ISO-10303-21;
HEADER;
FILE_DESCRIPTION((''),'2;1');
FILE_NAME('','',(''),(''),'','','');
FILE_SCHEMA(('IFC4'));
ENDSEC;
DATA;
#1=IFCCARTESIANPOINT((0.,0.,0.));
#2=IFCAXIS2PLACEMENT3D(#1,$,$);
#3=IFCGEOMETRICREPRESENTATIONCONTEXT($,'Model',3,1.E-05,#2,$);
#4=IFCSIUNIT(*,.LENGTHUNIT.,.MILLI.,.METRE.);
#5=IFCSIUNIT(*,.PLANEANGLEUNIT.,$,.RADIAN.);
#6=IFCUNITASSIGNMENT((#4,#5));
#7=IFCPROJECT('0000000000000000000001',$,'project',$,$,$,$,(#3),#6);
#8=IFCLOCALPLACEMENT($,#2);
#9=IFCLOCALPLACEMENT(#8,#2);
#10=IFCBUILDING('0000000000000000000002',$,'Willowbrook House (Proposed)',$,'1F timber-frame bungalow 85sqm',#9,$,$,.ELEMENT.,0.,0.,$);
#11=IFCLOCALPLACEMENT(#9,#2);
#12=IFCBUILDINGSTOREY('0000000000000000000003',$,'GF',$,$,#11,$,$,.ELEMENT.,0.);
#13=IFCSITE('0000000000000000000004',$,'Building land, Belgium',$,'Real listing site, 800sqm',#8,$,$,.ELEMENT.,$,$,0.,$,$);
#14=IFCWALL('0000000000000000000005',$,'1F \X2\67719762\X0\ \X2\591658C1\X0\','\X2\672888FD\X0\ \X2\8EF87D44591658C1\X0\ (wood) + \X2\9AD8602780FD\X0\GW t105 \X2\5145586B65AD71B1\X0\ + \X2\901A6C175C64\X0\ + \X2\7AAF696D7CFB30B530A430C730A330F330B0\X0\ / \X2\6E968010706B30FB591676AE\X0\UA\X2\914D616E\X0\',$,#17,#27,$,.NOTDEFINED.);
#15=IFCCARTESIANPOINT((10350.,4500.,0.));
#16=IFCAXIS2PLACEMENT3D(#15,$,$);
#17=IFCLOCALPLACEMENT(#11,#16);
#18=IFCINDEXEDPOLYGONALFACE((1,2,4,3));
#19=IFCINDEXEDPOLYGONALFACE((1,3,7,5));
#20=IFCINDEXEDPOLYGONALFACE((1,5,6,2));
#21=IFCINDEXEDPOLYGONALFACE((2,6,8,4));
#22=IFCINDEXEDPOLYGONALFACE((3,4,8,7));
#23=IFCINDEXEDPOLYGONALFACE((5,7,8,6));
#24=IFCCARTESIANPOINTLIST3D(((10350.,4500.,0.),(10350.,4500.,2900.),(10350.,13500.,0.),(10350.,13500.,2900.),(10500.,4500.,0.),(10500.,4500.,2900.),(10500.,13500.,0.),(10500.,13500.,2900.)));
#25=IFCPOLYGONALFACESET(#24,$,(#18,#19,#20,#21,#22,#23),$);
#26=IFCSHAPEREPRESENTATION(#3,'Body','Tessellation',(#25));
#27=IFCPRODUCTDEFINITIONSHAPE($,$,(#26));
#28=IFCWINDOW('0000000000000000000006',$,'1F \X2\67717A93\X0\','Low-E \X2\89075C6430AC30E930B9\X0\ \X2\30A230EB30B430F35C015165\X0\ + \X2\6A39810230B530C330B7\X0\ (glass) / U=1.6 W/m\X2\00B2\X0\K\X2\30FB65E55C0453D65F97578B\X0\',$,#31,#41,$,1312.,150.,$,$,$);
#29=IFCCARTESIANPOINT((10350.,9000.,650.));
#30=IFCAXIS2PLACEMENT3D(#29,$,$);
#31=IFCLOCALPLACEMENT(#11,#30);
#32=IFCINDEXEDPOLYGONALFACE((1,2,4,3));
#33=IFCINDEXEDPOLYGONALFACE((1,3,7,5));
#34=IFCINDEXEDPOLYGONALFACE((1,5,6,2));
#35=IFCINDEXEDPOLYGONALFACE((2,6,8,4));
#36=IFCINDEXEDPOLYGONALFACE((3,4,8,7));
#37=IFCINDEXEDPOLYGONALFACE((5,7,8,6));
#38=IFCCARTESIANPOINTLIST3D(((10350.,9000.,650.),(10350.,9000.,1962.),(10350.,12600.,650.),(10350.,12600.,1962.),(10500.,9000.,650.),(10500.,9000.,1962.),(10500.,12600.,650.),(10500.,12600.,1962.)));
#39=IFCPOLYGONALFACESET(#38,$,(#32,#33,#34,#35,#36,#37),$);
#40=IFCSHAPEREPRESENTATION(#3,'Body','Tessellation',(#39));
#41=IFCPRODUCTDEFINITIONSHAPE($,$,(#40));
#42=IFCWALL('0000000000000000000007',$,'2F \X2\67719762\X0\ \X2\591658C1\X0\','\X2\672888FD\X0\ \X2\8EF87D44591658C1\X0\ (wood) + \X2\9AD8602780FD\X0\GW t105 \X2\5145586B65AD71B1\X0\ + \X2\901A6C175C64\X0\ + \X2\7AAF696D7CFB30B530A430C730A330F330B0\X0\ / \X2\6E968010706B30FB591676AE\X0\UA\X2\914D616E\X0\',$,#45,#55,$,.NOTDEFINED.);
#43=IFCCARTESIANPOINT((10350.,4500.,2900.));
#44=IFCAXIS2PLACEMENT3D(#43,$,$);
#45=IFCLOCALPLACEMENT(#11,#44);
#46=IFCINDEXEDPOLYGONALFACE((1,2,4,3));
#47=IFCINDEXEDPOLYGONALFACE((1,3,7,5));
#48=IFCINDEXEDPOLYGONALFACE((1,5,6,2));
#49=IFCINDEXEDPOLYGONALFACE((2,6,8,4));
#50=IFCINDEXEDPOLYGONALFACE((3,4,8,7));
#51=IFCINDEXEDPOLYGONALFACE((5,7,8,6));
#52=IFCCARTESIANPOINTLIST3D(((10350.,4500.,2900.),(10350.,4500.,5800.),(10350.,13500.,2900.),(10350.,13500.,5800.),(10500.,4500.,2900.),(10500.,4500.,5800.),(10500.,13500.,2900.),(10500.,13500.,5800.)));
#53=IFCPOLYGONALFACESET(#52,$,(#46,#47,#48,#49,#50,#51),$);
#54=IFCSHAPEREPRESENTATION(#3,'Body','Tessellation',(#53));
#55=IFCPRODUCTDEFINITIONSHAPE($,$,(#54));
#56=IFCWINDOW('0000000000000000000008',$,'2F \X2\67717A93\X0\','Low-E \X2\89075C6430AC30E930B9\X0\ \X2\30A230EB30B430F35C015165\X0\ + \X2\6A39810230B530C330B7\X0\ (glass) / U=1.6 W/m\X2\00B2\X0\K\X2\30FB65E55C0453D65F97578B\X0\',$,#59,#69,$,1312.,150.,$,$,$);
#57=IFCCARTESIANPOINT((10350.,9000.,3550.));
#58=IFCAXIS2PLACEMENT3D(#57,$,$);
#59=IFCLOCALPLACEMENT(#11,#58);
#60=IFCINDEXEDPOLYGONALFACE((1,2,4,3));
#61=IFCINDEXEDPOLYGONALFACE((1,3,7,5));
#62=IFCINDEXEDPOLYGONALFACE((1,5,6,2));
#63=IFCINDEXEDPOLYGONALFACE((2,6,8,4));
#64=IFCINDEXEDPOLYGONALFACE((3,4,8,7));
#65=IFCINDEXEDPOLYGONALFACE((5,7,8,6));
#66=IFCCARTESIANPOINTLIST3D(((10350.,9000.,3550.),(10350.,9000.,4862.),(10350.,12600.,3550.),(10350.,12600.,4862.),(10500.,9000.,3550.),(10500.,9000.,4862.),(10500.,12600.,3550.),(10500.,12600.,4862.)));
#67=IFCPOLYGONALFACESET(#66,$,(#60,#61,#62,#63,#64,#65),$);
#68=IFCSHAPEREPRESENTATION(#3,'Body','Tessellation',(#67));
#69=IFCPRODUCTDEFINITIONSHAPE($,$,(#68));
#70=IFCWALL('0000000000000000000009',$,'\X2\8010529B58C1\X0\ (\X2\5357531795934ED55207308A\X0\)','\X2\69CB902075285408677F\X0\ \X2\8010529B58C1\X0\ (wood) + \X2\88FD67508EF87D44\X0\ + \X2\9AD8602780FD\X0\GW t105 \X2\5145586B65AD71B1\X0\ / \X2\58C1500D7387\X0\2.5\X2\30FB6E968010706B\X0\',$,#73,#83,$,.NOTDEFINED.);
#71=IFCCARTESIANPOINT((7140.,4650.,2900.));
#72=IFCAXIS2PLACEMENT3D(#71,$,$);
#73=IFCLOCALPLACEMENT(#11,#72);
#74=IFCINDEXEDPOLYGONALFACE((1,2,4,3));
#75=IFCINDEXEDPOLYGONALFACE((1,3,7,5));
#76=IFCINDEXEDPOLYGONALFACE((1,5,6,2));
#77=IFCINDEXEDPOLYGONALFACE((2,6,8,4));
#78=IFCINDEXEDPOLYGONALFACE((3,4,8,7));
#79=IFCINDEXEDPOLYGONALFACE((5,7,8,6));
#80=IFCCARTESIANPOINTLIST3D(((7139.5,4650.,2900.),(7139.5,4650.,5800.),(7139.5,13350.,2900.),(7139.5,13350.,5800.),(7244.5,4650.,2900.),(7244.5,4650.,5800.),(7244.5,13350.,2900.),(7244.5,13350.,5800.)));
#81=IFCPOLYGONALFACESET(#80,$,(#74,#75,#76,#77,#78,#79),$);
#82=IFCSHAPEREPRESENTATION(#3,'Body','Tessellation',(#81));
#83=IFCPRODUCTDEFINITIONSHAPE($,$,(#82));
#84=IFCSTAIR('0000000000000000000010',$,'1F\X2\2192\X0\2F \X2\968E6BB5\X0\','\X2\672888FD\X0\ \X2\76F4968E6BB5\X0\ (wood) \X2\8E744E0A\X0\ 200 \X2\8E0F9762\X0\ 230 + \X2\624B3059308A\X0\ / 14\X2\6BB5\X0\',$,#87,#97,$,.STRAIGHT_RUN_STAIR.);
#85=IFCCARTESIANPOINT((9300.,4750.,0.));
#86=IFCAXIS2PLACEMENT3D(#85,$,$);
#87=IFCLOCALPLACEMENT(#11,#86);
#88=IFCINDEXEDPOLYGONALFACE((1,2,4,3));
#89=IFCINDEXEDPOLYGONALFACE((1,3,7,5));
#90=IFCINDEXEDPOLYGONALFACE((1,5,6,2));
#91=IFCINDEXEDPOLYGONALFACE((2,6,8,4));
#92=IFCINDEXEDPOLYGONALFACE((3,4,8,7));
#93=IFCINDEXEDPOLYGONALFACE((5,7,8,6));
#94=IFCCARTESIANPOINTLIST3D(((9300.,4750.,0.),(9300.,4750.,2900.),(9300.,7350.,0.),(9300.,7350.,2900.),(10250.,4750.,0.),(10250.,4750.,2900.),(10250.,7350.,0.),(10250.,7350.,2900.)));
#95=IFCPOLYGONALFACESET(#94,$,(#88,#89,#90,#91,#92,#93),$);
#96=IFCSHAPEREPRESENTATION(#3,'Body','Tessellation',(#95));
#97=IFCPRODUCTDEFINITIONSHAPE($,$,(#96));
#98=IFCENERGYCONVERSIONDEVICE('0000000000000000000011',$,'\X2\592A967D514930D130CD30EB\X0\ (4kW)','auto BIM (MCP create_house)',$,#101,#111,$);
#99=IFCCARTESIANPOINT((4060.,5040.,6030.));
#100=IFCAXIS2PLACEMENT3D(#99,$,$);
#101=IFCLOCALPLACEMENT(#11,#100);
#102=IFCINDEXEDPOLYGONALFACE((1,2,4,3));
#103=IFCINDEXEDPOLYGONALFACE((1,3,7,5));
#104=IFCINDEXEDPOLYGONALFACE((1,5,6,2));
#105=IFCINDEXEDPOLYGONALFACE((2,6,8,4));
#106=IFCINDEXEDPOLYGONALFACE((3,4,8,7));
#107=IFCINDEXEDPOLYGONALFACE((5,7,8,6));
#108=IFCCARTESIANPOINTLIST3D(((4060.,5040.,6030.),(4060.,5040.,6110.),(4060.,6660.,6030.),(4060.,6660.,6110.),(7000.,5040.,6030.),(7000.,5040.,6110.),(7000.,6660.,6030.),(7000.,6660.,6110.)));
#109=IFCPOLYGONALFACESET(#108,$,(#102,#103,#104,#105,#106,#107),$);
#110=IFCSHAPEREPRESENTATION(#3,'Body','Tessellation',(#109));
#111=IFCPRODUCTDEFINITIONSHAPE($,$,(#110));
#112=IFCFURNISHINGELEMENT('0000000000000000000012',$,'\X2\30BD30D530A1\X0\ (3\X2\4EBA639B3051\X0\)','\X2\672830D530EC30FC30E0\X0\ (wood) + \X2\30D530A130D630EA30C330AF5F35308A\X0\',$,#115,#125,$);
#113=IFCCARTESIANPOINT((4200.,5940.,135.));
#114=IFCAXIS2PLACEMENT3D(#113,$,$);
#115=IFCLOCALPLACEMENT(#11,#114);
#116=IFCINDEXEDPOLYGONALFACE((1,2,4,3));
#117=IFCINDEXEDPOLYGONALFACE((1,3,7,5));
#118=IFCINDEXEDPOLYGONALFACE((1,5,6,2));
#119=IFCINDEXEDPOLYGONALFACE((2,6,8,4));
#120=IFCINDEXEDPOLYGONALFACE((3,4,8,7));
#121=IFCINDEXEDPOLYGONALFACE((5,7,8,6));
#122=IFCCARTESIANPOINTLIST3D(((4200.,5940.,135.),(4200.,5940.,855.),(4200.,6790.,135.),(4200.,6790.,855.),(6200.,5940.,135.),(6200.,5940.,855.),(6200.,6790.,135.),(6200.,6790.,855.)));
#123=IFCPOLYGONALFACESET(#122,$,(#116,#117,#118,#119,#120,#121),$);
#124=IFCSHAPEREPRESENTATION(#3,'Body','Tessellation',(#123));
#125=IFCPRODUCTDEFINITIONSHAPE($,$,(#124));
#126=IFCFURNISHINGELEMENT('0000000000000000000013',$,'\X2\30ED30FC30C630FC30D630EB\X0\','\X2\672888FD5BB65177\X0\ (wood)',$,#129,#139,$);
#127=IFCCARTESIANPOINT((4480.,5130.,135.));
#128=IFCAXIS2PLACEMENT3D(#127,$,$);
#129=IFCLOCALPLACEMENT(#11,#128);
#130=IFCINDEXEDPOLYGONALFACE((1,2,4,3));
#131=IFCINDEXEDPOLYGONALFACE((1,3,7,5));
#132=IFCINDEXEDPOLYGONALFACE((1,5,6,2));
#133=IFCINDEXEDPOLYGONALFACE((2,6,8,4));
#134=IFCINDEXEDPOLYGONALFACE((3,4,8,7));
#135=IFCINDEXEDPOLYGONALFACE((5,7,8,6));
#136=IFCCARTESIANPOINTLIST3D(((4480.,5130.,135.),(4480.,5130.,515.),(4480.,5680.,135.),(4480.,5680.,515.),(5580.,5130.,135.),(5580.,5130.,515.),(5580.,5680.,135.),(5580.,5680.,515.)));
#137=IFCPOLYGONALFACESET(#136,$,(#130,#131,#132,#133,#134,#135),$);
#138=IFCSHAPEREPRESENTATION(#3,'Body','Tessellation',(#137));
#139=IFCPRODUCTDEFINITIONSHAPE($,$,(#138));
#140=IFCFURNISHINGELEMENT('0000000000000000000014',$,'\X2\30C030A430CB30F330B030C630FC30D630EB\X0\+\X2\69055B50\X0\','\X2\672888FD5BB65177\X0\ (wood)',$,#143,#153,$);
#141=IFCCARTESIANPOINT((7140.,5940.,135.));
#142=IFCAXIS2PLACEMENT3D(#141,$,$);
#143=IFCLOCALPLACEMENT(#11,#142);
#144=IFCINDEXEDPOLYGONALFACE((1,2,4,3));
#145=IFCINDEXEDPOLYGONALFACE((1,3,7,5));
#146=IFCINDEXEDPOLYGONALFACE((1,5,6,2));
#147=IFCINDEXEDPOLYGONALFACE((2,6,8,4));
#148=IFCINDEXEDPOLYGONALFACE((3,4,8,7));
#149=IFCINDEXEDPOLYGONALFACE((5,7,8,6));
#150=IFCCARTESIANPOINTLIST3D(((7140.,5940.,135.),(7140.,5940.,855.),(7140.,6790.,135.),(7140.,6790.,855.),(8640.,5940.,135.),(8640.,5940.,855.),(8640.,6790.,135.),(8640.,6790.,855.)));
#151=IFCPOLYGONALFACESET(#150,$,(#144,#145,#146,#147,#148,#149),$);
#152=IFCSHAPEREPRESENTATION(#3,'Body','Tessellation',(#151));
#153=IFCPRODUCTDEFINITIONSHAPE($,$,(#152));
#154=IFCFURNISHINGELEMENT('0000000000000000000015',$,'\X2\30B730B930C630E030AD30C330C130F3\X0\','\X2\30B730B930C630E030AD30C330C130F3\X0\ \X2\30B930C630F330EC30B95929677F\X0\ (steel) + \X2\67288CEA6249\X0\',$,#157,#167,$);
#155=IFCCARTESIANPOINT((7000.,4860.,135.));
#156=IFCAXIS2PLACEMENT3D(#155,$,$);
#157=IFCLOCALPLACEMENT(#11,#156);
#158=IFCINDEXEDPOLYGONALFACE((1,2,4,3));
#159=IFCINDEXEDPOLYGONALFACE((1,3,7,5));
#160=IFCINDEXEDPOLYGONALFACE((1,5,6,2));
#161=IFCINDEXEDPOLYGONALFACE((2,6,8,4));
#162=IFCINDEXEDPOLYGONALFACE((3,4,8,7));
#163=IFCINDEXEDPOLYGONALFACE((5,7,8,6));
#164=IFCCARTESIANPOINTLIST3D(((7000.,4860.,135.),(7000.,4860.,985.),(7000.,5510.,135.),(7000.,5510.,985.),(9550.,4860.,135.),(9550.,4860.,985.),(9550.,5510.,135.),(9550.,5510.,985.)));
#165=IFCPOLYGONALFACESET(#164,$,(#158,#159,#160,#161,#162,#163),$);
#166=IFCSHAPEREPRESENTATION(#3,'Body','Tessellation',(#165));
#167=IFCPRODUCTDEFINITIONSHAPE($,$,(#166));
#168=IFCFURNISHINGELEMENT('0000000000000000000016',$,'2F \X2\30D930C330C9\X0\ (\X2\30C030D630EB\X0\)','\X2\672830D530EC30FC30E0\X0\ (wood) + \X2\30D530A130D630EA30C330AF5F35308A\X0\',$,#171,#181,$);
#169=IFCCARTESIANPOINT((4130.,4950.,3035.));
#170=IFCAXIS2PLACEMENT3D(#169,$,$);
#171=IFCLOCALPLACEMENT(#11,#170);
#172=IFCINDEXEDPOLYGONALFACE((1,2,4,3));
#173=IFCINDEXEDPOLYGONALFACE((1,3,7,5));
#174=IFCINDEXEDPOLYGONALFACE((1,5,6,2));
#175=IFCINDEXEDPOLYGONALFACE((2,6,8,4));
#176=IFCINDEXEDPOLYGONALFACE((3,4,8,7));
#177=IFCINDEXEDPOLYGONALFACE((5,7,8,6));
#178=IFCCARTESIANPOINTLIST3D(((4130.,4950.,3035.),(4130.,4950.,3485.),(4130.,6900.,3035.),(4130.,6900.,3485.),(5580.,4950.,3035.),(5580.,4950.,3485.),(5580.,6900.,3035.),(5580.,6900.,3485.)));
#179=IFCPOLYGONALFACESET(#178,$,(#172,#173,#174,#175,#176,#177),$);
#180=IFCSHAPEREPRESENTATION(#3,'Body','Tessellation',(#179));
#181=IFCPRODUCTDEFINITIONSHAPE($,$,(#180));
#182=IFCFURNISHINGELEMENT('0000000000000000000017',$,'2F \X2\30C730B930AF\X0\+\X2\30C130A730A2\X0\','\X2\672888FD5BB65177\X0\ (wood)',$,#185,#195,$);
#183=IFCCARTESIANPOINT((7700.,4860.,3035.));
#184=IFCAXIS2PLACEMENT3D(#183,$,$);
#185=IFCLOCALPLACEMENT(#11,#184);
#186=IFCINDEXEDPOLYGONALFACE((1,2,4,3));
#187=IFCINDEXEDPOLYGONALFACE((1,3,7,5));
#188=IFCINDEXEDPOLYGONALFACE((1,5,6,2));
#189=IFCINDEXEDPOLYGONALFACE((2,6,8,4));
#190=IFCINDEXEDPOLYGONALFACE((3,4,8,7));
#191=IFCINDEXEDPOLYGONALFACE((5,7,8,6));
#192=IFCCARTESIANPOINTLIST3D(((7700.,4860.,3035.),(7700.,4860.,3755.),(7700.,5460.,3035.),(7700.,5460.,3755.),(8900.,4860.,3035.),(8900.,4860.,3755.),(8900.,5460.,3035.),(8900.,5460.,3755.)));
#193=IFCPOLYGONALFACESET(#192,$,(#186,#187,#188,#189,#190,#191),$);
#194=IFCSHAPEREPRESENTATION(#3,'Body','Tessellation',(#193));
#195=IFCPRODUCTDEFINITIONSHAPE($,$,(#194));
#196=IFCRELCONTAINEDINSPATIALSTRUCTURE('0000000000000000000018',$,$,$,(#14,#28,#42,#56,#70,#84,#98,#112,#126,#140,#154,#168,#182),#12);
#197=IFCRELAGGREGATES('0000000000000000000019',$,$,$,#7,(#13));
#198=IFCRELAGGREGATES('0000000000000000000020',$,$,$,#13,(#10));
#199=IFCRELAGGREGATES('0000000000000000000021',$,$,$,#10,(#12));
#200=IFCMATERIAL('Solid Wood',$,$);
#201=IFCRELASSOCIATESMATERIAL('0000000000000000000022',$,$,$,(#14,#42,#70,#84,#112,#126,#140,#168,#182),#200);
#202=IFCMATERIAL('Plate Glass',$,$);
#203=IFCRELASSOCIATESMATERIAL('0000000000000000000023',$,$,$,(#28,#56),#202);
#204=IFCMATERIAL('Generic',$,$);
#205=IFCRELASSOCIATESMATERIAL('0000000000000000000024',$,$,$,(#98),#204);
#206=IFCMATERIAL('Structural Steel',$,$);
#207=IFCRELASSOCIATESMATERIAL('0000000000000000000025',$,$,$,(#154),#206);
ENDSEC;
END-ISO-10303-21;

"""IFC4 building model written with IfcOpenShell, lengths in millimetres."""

from ifc_helpers import new_model, si_unit, frame, frame_2d, origin, place, context, project, spatial, rectangle, extrude, material, element, fill, save


model = new_model("IFC4")

# Units and contexts
model_context = context("Model", 3, precision=1e-05, world=origin())
ifc_project = project(units=[si_unit("LENGTHUNIT", "METRE", prefix="MILLI"), si_unit("PLANEANGLEUNIT", "RADIAN")], contexts=[model_context])

# Site, building, storey
site_placement = place(None, origin())
site = spatial("IfcSite", under=ifc_project, at=site_placement, Name="Building land, Belgium", ObjectType="Real listing site, 800sqm", CompositionType="ELEMENT", RefElevation=0.0)
building_placement = place(site_placement, origin())
building = spatial("IfcBuilding", under=site, at=building_placement, Name="Willowbrook House (Proposed)", ObjectType="1F timber-frame bungalow 85sqm", CompositionType="ELEMENT", ElevationOfRefHeight=0.0, ElevationOfTerrain=0.0)
storey_placement = place(building_placement, origin())
storey = spatial("IfcBuildingStorey", under=building, at=storey_placement, Name="GF", CompositionType="ELEMENT", Elevation=0.0)

# Wall, opening, window
ifc_material_1 = material(Name="Solid Wood")
wall_1_placement = place(storey_placement, frame((10350.0, 4500.0, 0.0)))
wall_1 = element("IfcWall", 1, at=wall_1_placement, inside=storey, material=ifc_material_1, Name="1F 東面 外壁", Description="木製 軸組外壁 (wood) + 高性能GW t105 充填断熱 + 通気層 + 窯業系サイディング / 準耐火・外皮UA配慮", PredefinedType="NOTDEFINED", context=model_context, shape_type="SweptSolid", body=[
    extrude(rectangle(XDim=150.0, YDim=9000.0, at=frame_2d((75.0, 4500.0))), frame((10350.0, 4500.0, 0.0)), (0.0, 0.0, 1.0), 2900.0),
])
opening_1_placement = place(storey_placement, frame((10350.0, 9000.0, 650.0)))
opening_1 = element("IfcOpeningElement", 2, at=opening_1_placement, cuts=wall_1, PredefinedType="NOTDEFINED", context=model_context, shape_type="SweptSolid", body=[
    extrude(rectangle(XDim=150.0, YDim=3600.0, at=frame_2d((75.0, 1800.0))), frame((10350.0, 9000.0, 650.0)), (0.0, 0.0, 1.0), 1312.0),
])
ifc_material_2 = material(Name="Plate Glass")
window_1_placement = place(storey_placement, frame((10350.0, 9000.0, 650.0)))
window_1 = element("IfcWindow", 3, at=window_1_placement, inside=storey, material=ifc_material_2, Name="1F 東窓", Description="Low-E 複層ガラス アルゴン封入 + 樹脂サッシ (glass) / U=1.6 W/m²K・日射取得型", OverallHeight=1312.0, OverallWidth=150.0, context=model_context, shape_type="SweptSolid", body=[
    extrude(rectangle(XDim=150.0, YDim=3600.0, at=frame_2d((75.0, 1800.0))), frame((10350.0, 9000.0, 650.0)), (0.0, 0.0, 1.0), 1312.0),
])
fill(opening_1, window_1)

# Wall, opening, window
wall_2_placement = place(storey_placement, frame((10350.0, 4500.0, 2900.0)))
wall_2 = element("IfcWall", 4, at=wall_2_placement, inside=storey, material=ifc_material_1, Name="2F 東面 外壁", Description="木製 軸組外壁 (wood) + 高性能GW t105 充填断熱 + 通気層 + 窯業系サイディング / 準耐火・外皮UA配慮", PredefinedType="NOTDEFINED", context=model_context, shape_type="SweptSolid", body=[
    extrude(rectangle(XDim=150.0, YDim=9000.0, at=frame_2d((75.0, 4500.0))), frame((10350.0, 4500.0, 2900.0)), (0.0, 0.0, 1.0), 2900.0),
])
opening_2_placement = place(storey_placement, frame((10350.0, 9000.0, 3550.0)))
opening_2 = element("IfcOpeningElement", 5, at=opening_2_placement, cuts=wall_2, PredefinedType="NOTDEFINED", context=model_context, shape_type="SweptSolid", body=[
    extrude(rectangle(XDim=150.0, YDim=3600.0, at=frame_2d((75.0, 1800.0))), frame((10350.0, 9000.0, 3550.0)), (0.0, 0.0, 1.0), 1312.0),
])
window_2_placement = place(storey_placement, frame((10350.0, 9000.0, 3550.0)))
window_2 = element("IfcWindow", 6, at=window_2_placement, inside=storey, material=ifc_material_2, Name="2F 東窓", Description="Low-E 複層ガラス アルゴン封入 + 樹脂サッシ (glass) / U=1.6 W/m²K・日射取得型", OverallHeight=1312.0, OverallWidth=150.0, context=model_context, shape_type="SweptSolid", body=[
    extrude(rectangle(XDim=150.0, YDim=3600.0, at=frame_2d((75.0, 1800.0))), frame((10350.0, 9000.0, 3550.0)), (0.0, 0.0, 1.0), 1312.0),
])
fill(opening_2, window_2)

# Wall
wall_3_placement = place(storey_placement, frame((7140.0, 4650.0, 2900.0)))
element("IfcWall", 7, at=wall_3_placement, inside=storey, material=ifc_material_1, Name="耐力壁 (南北間仕切り)", Description="構造用合板 耐力壁 (wood) + 製材軸組 + 高性能GW t105 充填断熱 / 壁倍率2.5・準耐火", PredefinedType="NOTDEFINED", context=model_context, shape_type="SweptSolid", body=[
    extrude(rectangle(XDim=105.0, YDim=8700.0, at=frame_2d((52.0, 4350.0))), frame((7140.0, 4650.0, 2900.0)), (0.0, 0.0, 1.0), 2900.0),
])

# Stair
stair_placement = place(storey_placement, frame((9300.0, 4750.0, 0.0)))
element("IfcStair", 8, at=stair_placement, inside=storey, material=ifc_material_1, Name="1F→2F 階段", Description="木製 直階段 (wood) 蹴上 200 踏面 230 + 手すり / 14段", PredefinedType="STRAIGHT_RUN_STAIR", context=model_context, shape_type="SweptSolid", body=[
    extrude(rectangle(XDim=950.0, YDim=2600.0, at=frame_2d((475.0, 1300.0))), frame((9300.0, 4750.0, 0.0)), (0.0, 0.0, 1.0), 2900.0),
])

# Energy conversion device
ifc_material_3 = material(Name="Generic")
energy_conversion_device_placement = place(storey_placement, frame((4060.0, 5040.0, 6030.0)))
element("IfcEnergyConversionDevice", 9, at=energy_conversion_device_placement, inside=storey, material=ifc_material_3, Name="太陽光パネル (4kW)", Description="auto BIM (MCP create_house)", context=model_context, shape_type="SweptSolid", body=[
    extrude(rectangle(XDim=2940.0, YDim=1620.0, at=frame_2d((1470.0, 810.0))), frame((4060.0, 5040.0, 6030.0)), (0.0, 0.0, 1.0), 80.0),
])

# Furnishing elements
furnishing_1_placement = place(storey_placement, frame((4200.0, 5940.0, 135.0)))
element("IfcFurnishingElement", 10, at=furnishing_1_placement, inside=storey, material=ifc_material_1, Name="ソファ (3人掛け)", Description="木フレーム (wood) + ファブリック張り", context=model_context, shape_type="SweptSolid", body=[
    extrude(rectangle(XDim=2000.0, YDim=850.0, at=frame_2d((1000.0, 425.0))), frame((4200.0, 5940.0, 135.0)), (0.0, 0.0, 1.0), 720.0),
])
furnishing_2_placement = place(storey_placement, frame((4480.0, 5130.0, 135.0)))
element("IfcFurnishingElement", 11, at=furnishing_2_placement, inside=storey, material=ifc_material_1, Name="ローテーブル", Description="木製家具 (wood)", context=model_context, shape_type="SweptSolid", body=[
    extrude(rectangle(XDim=1100.0, YDim=550.0, at=frame_2d((550.0, 275.0))), frame((4480.0, 5130.0, 135.0)), (0.0, 0.0, 1.0), 380.0),
])
furnishing_3_placement = place(storey_placement, frame((7140.0, 5940.0, 135.0)))
element("IfcFurnishingElement", 12, at=furnishing_3_placement, inside=storey, material=ifc_material_1, Name="ダイニングテーブル+椅子", Description="木製家具 (wood)", context=model_context, shape_type="SweptSolid", body=[
    extrude(rectangle(XDim=1500.0, YDim=850.0, at=frame_2d((750.0, 425.0))), frame((7140.0, 5940.0, 135.0)), (0.0, 0.0, 1.0), 720.0),
])
ifc_material_4 = material(Name="Structural Steel")
furnishing_4_placement = place(storey_placement, frame((7000.0, 4860.0, 135.0)))
element("IfcFurnishingElement", 13, at=furnishing_4_placement, inside=storey, material=ifc_material_4, Name="システムキッチン", Description="システムキッチン ステンレス天板 (steel) + 木質扉", context=model_context, shape_type="SweptSolid", body=[
    extrude(rectangle(XDim=2550.0, YDim=650.0, at=frame_2d((1275.0, 325.0))), frame((7000.0, 4860.0, 135.0)), (0.0, 0.0, 1.0), 850.0),
])
furnishing_5_placement = place(storey_placement, frame((4130.0, 4950.0, 3035.0)))
element("IfcFurnishingElement", 14, at=furnishing_5_placement, inside=storey, material=ifc_material_1, Name="2F ベッド (ダブル)", Description="木フレーム (wood) + ファブリック張り", context=model_context, shape_type="SweptSolid", body=[
    extrude(rectangle(XDim=1450.0, YDim=1950.0, at=frame_2d((725.0, 975.0))), frame((4130.0, 4950.0, 3035.0)), (0.0, 0.0, 1.0), 450.0),
])
furnishing_6_placement = place(storey_placement, frame((7700.0, 4860.0, 3035.0)))
element("IfcFurnishingElement", 15, at=furnishing_6_placement, inside=storey, material=ifc_material_1, Name="2F デスク+チェア", Description="木製家具 (wood)", context=model_context, shape_type="SweptSolid", body=[
    extrude(rectangle(XDim=1200.0, YDim=600.0, at=frame_2d((600.0, 300.0))), frame((7700.0, 4860.0, 3035.0)), (0.0, 0.0, 1.0), 720.0),
])

save(model, "model.ifc")
